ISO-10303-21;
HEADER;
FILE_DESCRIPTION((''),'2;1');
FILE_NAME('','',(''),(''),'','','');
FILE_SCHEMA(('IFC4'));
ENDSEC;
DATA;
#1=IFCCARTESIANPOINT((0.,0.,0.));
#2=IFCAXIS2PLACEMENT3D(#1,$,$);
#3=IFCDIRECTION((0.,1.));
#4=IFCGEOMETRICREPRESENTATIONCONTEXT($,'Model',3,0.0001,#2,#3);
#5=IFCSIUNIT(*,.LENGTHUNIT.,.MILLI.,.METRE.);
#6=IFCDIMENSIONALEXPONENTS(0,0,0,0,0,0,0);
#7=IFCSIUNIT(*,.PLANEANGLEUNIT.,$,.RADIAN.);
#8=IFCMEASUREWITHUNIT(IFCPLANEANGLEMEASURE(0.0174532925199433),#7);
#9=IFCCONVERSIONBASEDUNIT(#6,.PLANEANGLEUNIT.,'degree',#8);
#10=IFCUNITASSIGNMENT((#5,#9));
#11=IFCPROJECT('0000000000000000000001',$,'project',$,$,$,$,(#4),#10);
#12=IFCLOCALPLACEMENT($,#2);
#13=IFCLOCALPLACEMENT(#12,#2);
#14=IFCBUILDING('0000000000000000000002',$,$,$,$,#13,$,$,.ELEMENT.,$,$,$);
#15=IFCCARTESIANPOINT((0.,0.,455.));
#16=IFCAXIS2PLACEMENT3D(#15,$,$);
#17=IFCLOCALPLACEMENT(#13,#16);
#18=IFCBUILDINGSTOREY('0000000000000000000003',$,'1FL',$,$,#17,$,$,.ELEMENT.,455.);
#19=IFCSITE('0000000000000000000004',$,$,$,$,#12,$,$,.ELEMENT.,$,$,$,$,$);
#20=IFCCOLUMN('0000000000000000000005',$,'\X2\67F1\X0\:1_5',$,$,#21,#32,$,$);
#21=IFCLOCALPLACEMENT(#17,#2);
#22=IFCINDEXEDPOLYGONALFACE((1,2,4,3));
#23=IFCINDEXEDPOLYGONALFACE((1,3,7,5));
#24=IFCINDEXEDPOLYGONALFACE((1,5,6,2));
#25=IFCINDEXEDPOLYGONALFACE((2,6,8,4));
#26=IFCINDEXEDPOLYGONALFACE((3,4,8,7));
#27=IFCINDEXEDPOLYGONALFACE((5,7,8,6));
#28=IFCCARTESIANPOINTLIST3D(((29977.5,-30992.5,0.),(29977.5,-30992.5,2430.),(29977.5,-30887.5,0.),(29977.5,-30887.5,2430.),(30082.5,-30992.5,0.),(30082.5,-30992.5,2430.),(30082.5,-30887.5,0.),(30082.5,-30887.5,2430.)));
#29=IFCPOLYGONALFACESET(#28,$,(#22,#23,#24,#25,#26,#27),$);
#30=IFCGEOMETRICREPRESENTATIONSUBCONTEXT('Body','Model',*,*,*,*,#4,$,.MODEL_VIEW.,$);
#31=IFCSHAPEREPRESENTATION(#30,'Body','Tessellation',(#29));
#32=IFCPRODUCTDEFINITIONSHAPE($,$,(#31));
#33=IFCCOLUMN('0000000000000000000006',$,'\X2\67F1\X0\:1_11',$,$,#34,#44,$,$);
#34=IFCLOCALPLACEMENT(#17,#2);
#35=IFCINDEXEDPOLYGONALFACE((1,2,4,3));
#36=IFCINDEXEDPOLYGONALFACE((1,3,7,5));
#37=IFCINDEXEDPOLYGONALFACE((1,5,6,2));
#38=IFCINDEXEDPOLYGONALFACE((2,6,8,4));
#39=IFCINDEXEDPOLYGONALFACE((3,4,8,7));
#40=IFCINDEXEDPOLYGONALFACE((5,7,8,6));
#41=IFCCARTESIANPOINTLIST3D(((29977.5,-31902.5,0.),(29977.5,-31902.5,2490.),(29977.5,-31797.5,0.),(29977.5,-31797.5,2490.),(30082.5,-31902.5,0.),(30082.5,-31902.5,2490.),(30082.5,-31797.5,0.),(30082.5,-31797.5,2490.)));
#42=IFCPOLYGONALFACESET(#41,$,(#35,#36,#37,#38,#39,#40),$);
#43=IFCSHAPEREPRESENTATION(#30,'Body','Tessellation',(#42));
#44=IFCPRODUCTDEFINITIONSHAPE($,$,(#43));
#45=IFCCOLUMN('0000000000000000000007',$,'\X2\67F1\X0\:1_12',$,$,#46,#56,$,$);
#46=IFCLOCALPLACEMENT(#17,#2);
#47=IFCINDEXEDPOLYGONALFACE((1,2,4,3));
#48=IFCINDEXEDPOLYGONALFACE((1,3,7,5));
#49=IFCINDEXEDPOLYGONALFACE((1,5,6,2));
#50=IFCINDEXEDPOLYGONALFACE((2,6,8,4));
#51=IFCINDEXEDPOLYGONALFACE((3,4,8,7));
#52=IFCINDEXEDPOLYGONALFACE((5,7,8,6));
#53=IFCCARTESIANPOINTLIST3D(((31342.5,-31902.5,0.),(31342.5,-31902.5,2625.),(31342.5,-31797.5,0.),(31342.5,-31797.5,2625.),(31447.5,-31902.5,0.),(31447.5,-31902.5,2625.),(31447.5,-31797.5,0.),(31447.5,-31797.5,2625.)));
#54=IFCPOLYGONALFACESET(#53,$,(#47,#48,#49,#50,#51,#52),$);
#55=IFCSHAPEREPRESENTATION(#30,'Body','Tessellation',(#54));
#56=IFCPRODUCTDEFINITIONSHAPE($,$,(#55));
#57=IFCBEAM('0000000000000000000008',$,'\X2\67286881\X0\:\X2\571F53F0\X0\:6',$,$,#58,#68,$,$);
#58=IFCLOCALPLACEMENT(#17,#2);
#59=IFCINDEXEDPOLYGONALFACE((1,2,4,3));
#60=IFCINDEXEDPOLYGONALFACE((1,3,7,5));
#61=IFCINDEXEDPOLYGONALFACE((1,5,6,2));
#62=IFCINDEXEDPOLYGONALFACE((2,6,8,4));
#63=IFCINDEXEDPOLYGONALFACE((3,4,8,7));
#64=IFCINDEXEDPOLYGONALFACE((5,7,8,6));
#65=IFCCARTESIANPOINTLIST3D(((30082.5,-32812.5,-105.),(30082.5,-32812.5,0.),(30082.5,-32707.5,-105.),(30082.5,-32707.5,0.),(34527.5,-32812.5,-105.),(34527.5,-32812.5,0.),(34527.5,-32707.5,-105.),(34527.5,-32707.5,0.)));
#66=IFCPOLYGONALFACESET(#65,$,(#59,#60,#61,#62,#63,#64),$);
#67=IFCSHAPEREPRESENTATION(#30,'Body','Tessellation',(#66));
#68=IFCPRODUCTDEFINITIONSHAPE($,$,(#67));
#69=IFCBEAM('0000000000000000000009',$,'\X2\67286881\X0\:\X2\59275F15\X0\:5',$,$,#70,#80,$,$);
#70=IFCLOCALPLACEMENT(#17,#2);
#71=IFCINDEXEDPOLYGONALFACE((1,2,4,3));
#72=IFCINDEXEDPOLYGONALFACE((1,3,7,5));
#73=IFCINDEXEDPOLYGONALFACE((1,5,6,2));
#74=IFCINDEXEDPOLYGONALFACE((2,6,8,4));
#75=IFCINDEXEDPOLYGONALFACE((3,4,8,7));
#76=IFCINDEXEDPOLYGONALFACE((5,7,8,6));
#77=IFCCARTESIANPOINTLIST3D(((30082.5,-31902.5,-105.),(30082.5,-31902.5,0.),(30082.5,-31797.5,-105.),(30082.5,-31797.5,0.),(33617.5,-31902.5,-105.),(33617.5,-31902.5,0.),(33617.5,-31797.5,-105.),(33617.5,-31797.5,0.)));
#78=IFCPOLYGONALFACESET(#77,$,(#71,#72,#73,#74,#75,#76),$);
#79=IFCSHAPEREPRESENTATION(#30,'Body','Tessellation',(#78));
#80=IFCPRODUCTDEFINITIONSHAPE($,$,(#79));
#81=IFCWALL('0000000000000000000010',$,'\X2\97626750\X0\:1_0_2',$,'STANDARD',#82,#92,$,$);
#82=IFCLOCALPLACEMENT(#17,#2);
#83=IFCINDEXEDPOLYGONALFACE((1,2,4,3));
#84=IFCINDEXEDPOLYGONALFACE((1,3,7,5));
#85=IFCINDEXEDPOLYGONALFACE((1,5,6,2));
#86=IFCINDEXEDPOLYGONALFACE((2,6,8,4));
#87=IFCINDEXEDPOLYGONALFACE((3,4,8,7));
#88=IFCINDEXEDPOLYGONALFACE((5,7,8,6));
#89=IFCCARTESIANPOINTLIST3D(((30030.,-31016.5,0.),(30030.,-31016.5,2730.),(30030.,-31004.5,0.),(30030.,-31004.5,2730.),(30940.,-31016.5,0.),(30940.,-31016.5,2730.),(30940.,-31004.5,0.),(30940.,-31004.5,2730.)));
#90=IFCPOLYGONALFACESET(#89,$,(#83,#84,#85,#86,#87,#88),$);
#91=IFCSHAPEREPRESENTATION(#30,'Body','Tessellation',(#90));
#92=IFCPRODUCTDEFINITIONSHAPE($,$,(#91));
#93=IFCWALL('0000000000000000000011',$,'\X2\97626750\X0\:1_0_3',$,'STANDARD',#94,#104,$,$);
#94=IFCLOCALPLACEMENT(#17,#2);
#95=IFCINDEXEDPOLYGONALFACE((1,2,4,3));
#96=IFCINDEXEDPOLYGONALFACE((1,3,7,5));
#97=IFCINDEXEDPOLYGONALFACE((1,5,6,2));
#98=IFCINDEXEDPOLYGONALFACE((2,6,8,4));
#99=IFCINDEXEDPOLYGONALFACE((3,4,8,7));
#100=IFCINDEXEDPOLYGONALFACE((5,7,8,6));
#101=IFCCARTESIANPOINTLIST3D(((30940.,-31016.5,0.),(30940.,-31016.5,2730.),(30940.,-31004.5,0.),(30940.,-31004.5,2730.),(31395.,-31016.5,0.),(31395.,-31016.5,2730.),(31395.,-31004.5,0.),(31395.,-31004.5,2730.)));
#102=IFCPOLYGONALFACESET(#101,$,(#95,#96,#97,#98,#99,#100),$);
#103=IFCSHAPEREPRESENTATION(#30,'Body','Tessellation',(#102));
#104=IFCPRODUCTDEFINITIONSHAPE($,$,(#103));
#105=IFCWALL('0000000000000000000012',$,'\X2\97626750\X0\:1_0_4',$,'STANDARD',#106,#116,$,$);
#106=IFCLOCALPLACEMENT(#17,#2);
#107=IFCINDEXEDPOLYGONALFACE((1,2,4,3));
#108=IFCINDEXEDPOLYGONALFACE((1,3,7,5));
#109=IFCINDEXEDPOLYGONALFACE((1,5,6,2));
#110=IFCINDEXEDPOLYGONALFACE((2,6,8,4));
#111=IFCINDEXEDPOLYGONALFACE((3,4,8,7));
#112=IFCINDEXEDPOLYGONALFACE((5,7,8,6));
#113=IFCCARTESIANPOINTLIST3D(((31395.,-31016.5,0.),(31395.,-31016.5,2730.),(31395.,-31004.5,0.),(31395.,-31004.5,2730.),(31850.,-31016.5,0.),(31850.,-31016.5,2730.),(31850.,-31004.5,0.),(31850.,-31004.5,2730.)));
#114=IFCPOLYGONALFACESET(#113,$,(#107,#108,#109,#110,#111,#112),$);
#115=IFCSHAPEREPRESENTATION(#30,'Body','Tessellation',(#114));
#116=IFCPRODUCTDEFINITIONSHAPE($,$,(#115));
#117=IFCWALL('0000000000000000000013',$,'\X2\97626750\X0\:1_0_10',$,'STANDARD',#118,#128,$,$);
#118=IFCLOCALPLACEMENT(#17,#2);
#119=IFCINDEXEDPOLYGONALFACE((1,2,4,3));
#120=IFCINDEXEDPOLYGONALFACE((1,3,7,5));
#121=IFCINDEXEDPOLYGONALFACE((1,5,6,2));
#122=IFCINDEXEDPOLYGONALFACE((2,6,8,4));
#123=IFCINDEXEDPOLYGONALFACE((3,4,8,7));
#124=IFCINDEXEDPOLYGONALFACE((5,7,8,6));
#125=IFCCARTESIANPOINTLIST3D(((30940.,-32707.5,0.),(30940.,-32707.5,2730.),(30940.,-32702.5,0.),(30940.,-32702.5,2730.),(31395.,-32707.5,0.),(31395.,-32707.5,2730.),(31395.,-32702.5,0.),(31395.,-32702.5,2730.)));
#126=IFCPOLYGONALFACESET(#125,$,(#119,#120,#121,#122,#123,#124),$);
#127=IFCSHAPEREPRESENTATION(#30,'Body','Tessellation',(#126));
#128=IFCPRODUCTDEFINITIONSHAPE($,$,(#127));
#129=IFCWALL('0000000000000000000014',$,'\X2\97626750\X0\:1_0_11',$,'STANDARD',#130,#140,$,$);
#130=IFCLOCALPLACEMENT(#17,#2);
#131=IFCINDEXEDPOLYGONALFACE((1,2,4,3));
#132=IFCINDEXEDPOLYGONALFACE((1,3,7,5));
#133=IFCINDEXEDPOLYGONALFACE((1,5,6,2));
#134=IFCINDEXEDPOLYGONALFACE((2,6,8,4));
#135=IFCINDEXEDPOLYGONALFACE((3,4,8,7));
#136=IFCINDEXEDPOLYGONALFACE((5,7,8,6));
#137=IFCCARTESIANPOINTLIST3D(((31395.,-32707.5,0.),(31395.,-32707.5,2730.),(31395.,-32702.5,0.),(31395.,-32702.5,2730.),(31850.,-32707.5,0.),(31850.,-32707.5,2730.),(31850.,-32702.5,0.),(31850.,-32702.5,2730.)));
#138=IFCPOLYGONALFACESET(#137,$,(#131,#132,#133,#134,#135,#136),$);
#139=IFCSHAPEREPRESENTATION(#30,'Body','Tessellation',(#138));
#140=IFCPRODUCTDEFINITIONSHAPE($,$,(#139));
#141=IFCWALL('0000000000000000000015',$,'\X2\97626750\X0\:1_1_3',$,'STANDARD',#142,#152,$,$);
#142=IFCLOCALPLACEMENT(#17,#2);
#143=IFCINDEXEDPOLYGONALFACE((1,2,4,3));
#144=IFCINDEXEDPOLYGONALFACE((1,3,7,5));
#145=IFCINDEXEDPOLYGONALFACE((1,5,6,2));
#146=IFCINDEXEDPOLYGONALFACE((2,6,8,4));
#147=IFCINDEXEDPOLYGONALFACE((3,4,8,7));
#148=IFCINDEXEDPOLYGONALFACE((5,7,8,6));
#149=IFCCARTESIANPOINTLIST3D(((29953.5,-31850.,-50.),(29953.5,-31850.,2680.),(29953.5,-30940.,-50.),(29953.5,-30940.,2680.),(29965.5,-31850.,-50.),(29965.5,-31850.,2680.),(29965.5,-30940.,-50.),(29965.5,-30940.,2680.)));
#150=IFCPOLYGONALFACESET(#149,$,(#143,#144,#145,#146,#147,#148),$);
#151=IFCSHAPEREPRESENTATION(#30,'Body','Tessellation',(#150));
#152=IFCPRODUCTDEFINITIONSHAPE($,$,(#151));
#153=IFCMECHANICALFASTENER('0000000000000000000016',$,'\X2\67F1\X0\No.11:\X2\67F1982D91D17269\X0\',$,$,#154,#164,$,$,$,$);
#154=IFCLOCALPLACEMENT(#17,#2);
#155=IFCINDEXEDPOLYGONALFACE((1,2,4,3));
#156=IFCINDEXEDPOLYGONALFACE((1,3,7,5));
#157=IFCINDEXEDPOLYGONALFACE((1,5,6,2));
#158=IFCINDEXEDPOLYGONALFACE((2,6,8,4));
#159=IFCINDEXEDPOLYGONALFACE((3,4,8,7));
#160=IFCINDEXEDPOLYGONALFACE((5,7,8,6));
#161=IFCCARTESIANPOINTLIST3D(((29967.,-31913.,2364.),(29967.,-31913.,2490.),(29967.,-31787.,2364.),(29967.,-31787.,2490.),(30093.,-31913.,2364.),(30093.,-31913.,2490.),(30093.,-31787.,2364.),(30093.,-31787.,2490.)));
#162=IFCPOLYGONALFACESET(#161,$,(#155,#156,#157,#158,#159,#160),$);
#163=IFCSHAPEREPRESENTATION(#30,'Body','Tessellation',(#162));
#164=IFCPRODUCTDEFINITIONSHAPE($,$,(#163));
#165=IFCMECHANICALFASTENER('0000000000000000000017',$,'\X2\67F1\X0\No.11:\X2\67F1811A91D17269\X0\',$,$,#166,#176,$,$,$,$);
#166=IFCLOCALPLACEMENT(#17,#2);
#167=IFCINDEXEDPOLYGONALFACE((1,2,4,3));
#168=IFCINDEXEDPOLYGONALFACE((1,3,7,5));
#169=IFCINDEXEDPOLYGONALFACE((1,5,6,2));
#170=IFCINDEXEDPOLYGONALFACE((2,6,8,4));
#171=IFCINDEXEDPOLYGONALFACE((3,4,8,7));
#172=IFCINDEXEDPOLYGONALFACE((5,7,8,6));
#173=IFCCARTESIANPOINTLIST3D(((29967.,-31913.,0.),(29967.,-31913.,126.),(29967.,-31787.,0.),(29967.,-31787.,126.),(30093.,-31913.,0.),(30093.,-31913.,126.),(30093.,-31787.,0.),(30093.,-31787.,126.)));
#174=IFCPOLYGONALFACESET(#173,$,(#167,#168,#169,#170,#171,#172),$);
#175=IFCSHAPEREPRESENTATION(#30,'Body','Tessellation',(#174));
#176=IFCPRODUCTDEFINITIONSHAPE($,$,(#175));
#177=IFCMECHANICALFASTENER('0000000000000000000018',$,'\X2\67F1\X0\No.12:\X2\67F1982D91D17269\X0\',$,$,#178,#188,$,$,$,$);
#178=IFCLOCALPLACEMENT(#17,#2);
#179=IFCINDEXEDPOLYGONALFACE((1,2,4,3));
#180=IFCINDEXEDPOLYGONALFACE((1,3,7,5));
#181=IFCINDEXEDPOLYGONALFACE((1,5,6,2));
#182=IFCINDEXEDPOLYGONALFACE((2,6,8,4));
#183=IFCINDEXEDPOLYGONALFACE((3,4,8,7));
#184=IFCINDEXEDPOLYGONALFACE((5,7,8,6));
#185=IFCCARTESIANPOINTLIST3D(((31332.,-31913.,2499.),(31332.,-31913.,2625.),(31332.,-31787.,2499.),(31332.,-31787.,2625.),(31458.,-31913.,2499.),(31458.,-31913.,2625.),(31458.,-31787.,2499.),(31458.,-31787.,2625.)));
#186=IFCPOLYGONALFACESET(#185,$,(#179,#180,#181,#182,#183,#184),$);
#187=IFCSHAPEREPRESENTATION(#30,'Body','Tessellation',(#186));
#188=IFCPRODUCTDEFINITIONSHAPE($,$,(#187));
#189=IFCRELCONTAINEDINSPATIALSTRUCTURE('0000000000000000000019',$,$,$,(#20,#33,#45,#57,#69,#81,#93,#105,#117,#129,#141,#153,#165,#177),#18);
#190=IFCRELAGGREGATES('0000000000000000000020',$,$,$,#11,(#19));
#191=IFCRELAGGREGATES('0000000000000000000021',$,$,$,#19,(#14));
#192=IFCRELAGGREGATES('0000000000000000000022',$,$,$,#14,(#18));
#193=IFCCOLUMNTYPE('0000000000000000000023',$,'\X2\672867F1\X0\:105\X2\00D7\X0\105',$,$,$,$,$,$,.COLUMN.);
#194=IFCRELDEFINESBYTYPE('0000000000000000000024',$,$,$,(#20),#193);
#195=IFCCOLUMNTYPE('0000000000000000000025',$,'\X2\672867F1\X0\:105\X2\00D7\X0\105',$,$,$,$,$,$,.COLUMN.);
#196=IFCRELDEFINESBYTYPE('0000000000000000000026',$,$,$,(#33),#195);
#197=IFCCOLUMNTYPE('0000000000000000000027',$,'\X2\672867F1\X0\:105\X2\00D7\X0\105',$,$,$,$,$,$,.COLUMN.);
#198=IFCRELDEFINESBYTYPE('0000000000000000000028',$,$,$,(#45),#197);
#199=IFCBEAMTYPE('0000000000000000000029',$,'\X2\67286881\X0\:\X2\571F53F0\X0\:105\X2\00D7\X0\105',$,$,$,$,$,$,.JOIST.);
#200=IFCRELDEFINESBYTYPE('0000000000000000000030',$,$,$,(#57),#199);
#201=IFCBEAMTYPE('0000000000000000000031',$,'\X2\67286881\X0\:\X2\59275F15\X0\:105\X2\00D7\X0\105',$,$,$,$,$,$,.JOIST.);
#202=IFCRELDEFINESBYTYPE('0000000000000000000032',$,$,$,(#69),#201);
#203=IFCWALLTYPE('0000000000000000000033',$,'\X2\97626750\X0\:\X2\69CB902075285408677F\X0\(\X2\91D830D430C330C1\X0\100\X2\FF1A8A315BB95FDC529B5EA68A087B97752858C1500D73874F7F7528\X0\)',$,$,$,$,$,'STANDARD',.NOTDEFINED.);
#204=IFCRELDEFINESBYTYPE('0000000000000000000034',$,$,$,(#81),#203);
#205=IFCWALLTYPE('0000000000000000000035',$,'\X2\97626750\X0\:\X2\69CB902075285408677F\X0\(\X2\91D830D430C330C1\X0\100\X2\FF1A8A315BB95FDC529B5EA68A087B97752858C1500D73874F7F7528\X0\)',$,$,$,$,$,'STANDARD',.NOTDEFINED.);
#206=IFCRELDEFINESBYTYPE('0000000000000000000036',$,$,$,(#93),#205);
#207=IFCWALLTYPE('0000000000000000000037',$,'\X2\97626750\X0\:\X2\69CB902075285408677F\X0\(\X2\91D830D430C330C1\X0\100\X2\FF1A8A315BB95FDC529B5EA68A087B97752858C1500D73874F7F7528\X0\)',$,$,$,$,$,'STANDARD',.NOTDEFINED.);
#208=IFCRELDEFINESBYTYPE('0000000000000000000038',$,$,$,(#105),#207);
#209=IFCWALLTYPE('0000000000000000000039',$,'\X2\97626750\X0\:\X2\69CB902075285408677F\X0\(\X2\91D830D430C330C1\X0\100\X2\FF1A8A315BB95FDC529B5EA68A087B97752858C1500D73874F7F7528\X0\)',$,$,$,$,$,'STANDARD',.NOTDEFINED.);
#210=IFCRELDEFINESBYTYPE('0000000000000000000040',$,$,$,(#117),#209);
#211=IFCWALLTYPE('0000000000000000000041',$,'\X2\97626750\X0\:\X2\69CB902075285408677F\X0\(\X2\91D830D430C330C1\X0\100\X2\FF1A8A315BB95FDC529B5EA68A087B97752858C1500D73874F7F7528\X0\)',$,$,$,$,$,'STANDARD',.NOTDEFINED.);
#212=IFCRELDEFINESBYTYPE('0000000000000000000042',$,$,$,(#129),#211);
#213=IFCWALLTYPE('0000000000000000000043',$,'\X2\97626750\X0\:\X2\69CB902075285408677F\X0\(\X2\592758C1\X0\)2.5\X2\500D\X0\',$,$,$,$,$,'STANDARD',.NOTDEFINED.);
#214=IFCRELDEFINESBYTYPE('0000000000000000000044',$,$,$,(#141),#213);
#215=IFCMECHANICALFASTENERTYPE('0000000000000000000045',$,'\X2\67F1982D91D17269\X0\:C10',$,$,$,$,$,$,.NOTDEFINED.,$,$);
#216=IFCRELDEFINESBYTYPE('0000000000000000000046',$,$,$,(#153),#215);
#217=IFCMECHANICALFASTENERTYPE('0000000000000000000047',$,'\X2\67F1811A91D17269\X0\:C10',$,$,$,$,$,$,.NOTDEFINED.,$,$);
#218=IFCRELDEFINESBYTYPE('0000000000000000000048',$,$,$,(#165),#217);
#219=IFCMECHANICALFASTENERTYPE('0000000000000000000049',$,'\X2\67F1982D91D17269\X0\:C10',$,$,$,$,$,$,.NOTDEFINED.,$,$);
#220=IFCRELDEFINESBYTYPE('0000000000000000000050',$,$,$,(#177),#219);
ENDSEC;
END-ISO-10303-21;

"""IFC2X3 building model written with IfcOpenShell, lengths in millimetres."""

from ifc_helpers import new_model, entity, si_unit, converted_unit, direction, frame, origin, origin_with_axes, origin_2d, place, context, subcontext, project, spatial, polyline, rectangle, outline, extrude, type_object, element, save


model = new_model("IFC2X3")

# Units and contexts
model_context = context("Model", 3, precision=0.0001, world=origin(), true_north=direction((0.0, 1.0)))
body_context = subcontext(model_context, "Body", "Model", "MODEL_VIEW")
ifc_project = project(units=[si_unit("LENGTHUNIT", "METRE", prefix="MILLI"), converted_unit("PLANEANGLEUNIT", "degree", entity("IfcPlaneAngleMeasure", 0.0174532925199433), si_unit("PLANEANGLEUNIT", "RADIAN"), dimensions=[0, 0, 0, 0, 0, 0, 0])], contexts=[model_context])

# Site, building, storey
site_placement = place(None, origin())
site = spatial("IfcSite", under=ifc_project, at=site_placement, CompositionType="ELEMENT")
building_placement = place(site_placement, origin())
building = spatial("IfcBuilding", under=site, at=building_placement, CompositionType="ELEMENT")
storey_placement = place(building_placement, frame((0.0, 0.0, 455.0)))
storey = spatial("IfcBuildingStorey", under=building, at=storey_placement, Name="1FL", CompositionType="ELEMENT", Elevation=455.0)

# Columns
column_type_1 = type_object("IfcColumnType", Name="木柱:105×105", PredefinedType="COLUMN")
column_1_placement = place(storey_placement, frame((30030.0, -30940.0, 0.0)))
element("IfcColumn", 1, at=column_1_placement, inside=storey, type_object=column_type_1, Name="柱:1_5", context=body_context, shape_type="SweptSolid", body=[
    extrude(rectangle(XDim=105.0, YDim=105.0, at=origin_2d()), origin_with_axes(), (0.0, 0.0, 1.0), 2430.0),
])
column_type_2 = type_object("IfcColumnType", Name="木柱:105×105", PredefinedType="COLUMN")
column_2_placement = place(storey_placement, frame((30030.0, -31850.0, 0.0)))
element("IfcColumn", 2, at=column_2_placement, inside=storey, type_object=column_type_2, Name="柱:1_11", context=body_context, shape_type="SweptSolid", body=[
    extrude(rectangle(XDim=105.0, YDim=105.0, at=origin_2d()), origin_with_axes(), (0.0, 0.0, 1.0), 2490.0),
])
column_type_3 = type_object("IfcColumnType", Name="木柱:105×105", PredefinedType="COLUMN")
column_3_placement = place(storey_placement, frame((31395.0, -31850.0, 0.0)))
element("IfcColumn", 3, at=column_3_placement, inside=storey, type_object=column_type_3, Name="柱:1_12", context=body_context, shape_type="SweptSolid", body=[
    extrude(rectangle(XDim=105.0, YDim=105.0, at=origin_2d()), origin_with_axes(), (0.0, 0.0, 1.0), 2625.0),
])

# Beams
beam_type_1 = type_object("IfcBeamType", Name="木梁:土台:105×105", PredefinedType="JOIST")
beam_1_placement = place(storey_placement, frame((30082.5, -32760.0, -52.5), z_axis=(1.0, 0.0, 0.0), x_axis=(0.0, 1.0, 0.0)))
element("IfcBeam", 4, at=beam_1_placement, inside=storey, type_object=beam_type_1, Name="木梁:土台:6", context=body_context, shape_type="SweptSolid", body=[
    extrude(rectangle(XDim=105.0, YDim=105.0, at=origin_2d()), origin_with_axes(), (0.0, 0.0, 1.0), 4445.0),
])
beam_type_2 = type_object("IfcBeamType", Name="木梁:大引:105×105", PredefinedType="JOIST")
beam_2_placement = place(storey_placement, frame((30082.5, -31850.0, -52.5), z_axis=(1.0, 0.0, 0.0), x_axis=(0.0, 1.0, 0.0)))
element("IfcBeam", 5, at=beam_2_placement, inside=storey, type_object=beam_type_2, Name="木梁:大引:5", context=body_context, shape_type="SweptSolid", body=[
    extrude(rectangle(XDim=105.0, YDim=105.0, at=origin_2d()), origin_with_axes(), (0.0, 0.0, 1.0), 3535.0),
])

# Walls
wall_type_1 = type_object("IfcWallType", Name="面材:構造用合板(釘ピッチ100：許容応力度計算用壁倍率使用)", ElementType="STANDARD", PredefinedType="NOTDEFINED")
wall_1_placement = place(storey_placement, frame((30485.0, -31004.5, 0.0), z_axis=(0.0, -1.0, 0.0), x_axis=(1.0, 0.0, 0.0)))
element("IfcWall", 6, at=wall_1_placement, inside=storey, type_object=wall_type_1, Name="面材:1_0_2", ObjectType="STANDARD", context=body_context, shape_type="SweptSolid", body=[
    extrude(outline(polyline([(455.0, 0.0, 0.0), (-455.0, 0.0, 0.0), (-455.0, 2730.0, 0.0), (455.0, 2730.0, 0.0), (455.0, 0.0, 0.0)])), origin_with_axes(), (0.0, 0.0, 1.0), 12.0),
])
wall_type_2 = type_object("IfcWallType", Name="面材:構造用合板(釘ピッチ100：許容応力度計算用壁倍率使用)", ElementType="STANDARD", PredefinedType="NOTDEFINED")
wall_2_placement = place(storey_placement, frame((31167.5, -31004.5, 0.0), z_axis=(0.0, -1.0, 0.0), x_axis=(1.0, 0.0, 0.0)))
element("IfcWall", 7, at=wall_2_placement, inside=storey, type_object=wall_type_2, Name="面材:1_0_3", ObjectType="STANDARD", context=body_context, shape_type="SweptSolid", body=[
    extrude(outline(polyline([(227.5, 0.0, 0.0), (-227.5, 0.0, 0.0), (-227.5, 2730.0, 0.0), (227.5, 2730.0, 0.0), (227.5, 0.0, 0.0)])), origin_with_axes(), (0.0, 0.0, 1.0), 12.0),
])
wall_type_3 = type_object("IfcWallType", Name="面材:構造用合板(釘ピッチ100：許容応力度計算用壁倍率使用)", ElementType="STANDARD", PredefinedType="NOTDEFINED")
wall_3_placement = place(storey_placement, frame((31622.5, -31004.5, 0.0), z_axis=(0.0, -1.0, 0.0), x_axis=(1.0, 0.0, 0.0)))
element("IfcWall", 8, at=wall_3_placement, inside=storey, type_object=wall_type_3, Name="面材:1_0_4", ObjectType="STANDARD", context=body_context, shape_type="SweptSolid", body=[
    extrude(outline(polyline([(227.5, 0.0, 0.0), (-227.5, 0.0, 0.0), (-227.5, 2730.0, 0.0), (227.5, 2730.0, 0.0), (227.5, 0.0, 0.0)])), origin_with_axes(), (0.0, 0.0, 1.0), 12.0),
])
wall_type_4 = type_object("IfcWallType", Name="面材:構造用合板(釘ピッチ100：許容応力度計算用壁倍率使用)", ElementType="STANDARD", PredefinedType="NOTDEFINED")
wall_4_placement = place(storey_placement, frame((31167.5, -32702.5, 0.0), z_axis=(0.0, -1.0, 0.0), x_axis=(1.0, 0.0, 0.0)))
element("IfcWall", 9, at=wall_4_placement, inside=storey, type_object=wall_type_4, Name="面材:1_0_10", ObjectType="STANDARD", context=body_context, shape_type="SweptSolid", body=[
    extrude(outline(polyline([(227.5, 0.0, 0.0), (-227.5, 0.0, 0.0), (-227.5, 2730.0, 0.0), (227.5, 2730.0, 0.0), (227.5, 0.0, 0.0)])), origin_with_axes(), (0.0, 0.0, 1.0), 5.0),
])
wall_type_5 = type_object("IfcWallType", Name="面材:構造用合板(釘ピッチ100：許容応力度計算用壁倍率使用)", ElementType="STANDARD", PredefinedType="NOTDEFINED")
wall_5_placement = place(storey_placement, frame((31622.5, -32702.5, 0.0), z_axis=(0.0, -1.0, 0.0), x_axis=(1.0, 0.0, 0.0)))
element("IfcWall", 10, at=wall_5_placement, inside=storey, type_object=wall_type_5, Name="面材:1_0_11", ObjectType="STANDARD", context=body_context, shape_type="SweptSolid", body=[
    extrude(outline(polyline([(227.5, 0.0, 0.0), (-227.5, 0.0, 0.0), (-227.5, 2730.0, 0.0), (227.5, 2730.0, 0.0), (227.5, 0.0, 0.0)])), origin_with_axes(), (0.0, 0.0, 1.0), 5.0),
])
wall_type_6 = type_object("IfcWallType", Name="面材:構造用合板(大壁)2.5倍", ElementType="STANDARD", PredefinedType="NOTDEFINED")
wall_6_placement = place(storey_placement, frame((29965.5, -31395.0, -50.0), z_axis=(-1.0, 0.0, 0.0), x_axis=(0.0, -1.0, 0.0)))
element("IfcWall", 11, at=wall_6_placement, inside=storey, type_object=wall_type_6, Name="面材:1_1_3", ObjectType="STANDARD", context=body_context, shape_type="SweptSolid", body=[
    extrude(outline(polyline([(455.0, 0.0, 0.0), (-455.0, 0.0, 0.0), (-455.0, 2730.0, 0.0), (455.0, 2730.0, 0.0), (455.0, 0.0, 0.0)])), origin_with_axes(), (0.0, 0.0, 1.0), 12.0),
])

# Mechanical fasteners
mechanical_fastener_type_1 = type_object("IfcMechanicalFastenerType", Name="柱頭金物:C10")
mechanical_fastener_1_placement = place(storey_placement, frame((30030.0, -31850.0, 2364.0)))
element("IfcMechanicalFastener", 12, at=mechanical_fastener_1_placement, inside=storey, type_object=mechanical_fastener_type_1, Name="柱No.11:柱頭金物", context=body_context, shape_type="SweptSolid", body=[
    extrude(rectangle(XDim=126.0, YDim=126.0, at=origin_2d()), origin_with_axes(), (0.0, 0.0, 1.0), 126.0),
])
mechanical_fastener_type_2 = type_object("IfcMechanicalFastenerType", Name="柱脚金物:C10")
mechanical_fastener_2_placement = place(storey_placement, frame((30030.0, -31850.0, 0.0)))
element("IfcMechanicalFastener", 13, at=mechanical_fastener_2_placement, inside=storey, type_object=mechanical_fastener_type_2, Name="柱No.11:柱脚金物", context=body_context, shape_type="SweptSolid", body=[
    extrude(rectangle(XDim=126.0, YDim=126.0, at=origin_2d()), origin_with_axes(), (0.0, 0.0, 1.0), 126.0),
])
mechanical_fastener_type_3 = type_object("IfcMechanicalFastenerType", Name="柱頭金物:C10")
mechanical_fastener_3_placement = place(storey_placement, frame((31395.0, -31850.0, 2499.0)))
element("IfcMechanicalFastener", 14, at=mechanical_fastener_3_placement, inside=storey, type_object=mechanical_fastener_type_3, Name="柱No.12:柱頭金物", context=body_context, shape_type="SweptSolid", body=[
    extrude(rectangle(XDim=126.0, YDim=126.0, at=origin_2d()), origin_with_axes(), (0.0, 0.0, 1.0), 126.0),
])

save(model, "model.ifc")
